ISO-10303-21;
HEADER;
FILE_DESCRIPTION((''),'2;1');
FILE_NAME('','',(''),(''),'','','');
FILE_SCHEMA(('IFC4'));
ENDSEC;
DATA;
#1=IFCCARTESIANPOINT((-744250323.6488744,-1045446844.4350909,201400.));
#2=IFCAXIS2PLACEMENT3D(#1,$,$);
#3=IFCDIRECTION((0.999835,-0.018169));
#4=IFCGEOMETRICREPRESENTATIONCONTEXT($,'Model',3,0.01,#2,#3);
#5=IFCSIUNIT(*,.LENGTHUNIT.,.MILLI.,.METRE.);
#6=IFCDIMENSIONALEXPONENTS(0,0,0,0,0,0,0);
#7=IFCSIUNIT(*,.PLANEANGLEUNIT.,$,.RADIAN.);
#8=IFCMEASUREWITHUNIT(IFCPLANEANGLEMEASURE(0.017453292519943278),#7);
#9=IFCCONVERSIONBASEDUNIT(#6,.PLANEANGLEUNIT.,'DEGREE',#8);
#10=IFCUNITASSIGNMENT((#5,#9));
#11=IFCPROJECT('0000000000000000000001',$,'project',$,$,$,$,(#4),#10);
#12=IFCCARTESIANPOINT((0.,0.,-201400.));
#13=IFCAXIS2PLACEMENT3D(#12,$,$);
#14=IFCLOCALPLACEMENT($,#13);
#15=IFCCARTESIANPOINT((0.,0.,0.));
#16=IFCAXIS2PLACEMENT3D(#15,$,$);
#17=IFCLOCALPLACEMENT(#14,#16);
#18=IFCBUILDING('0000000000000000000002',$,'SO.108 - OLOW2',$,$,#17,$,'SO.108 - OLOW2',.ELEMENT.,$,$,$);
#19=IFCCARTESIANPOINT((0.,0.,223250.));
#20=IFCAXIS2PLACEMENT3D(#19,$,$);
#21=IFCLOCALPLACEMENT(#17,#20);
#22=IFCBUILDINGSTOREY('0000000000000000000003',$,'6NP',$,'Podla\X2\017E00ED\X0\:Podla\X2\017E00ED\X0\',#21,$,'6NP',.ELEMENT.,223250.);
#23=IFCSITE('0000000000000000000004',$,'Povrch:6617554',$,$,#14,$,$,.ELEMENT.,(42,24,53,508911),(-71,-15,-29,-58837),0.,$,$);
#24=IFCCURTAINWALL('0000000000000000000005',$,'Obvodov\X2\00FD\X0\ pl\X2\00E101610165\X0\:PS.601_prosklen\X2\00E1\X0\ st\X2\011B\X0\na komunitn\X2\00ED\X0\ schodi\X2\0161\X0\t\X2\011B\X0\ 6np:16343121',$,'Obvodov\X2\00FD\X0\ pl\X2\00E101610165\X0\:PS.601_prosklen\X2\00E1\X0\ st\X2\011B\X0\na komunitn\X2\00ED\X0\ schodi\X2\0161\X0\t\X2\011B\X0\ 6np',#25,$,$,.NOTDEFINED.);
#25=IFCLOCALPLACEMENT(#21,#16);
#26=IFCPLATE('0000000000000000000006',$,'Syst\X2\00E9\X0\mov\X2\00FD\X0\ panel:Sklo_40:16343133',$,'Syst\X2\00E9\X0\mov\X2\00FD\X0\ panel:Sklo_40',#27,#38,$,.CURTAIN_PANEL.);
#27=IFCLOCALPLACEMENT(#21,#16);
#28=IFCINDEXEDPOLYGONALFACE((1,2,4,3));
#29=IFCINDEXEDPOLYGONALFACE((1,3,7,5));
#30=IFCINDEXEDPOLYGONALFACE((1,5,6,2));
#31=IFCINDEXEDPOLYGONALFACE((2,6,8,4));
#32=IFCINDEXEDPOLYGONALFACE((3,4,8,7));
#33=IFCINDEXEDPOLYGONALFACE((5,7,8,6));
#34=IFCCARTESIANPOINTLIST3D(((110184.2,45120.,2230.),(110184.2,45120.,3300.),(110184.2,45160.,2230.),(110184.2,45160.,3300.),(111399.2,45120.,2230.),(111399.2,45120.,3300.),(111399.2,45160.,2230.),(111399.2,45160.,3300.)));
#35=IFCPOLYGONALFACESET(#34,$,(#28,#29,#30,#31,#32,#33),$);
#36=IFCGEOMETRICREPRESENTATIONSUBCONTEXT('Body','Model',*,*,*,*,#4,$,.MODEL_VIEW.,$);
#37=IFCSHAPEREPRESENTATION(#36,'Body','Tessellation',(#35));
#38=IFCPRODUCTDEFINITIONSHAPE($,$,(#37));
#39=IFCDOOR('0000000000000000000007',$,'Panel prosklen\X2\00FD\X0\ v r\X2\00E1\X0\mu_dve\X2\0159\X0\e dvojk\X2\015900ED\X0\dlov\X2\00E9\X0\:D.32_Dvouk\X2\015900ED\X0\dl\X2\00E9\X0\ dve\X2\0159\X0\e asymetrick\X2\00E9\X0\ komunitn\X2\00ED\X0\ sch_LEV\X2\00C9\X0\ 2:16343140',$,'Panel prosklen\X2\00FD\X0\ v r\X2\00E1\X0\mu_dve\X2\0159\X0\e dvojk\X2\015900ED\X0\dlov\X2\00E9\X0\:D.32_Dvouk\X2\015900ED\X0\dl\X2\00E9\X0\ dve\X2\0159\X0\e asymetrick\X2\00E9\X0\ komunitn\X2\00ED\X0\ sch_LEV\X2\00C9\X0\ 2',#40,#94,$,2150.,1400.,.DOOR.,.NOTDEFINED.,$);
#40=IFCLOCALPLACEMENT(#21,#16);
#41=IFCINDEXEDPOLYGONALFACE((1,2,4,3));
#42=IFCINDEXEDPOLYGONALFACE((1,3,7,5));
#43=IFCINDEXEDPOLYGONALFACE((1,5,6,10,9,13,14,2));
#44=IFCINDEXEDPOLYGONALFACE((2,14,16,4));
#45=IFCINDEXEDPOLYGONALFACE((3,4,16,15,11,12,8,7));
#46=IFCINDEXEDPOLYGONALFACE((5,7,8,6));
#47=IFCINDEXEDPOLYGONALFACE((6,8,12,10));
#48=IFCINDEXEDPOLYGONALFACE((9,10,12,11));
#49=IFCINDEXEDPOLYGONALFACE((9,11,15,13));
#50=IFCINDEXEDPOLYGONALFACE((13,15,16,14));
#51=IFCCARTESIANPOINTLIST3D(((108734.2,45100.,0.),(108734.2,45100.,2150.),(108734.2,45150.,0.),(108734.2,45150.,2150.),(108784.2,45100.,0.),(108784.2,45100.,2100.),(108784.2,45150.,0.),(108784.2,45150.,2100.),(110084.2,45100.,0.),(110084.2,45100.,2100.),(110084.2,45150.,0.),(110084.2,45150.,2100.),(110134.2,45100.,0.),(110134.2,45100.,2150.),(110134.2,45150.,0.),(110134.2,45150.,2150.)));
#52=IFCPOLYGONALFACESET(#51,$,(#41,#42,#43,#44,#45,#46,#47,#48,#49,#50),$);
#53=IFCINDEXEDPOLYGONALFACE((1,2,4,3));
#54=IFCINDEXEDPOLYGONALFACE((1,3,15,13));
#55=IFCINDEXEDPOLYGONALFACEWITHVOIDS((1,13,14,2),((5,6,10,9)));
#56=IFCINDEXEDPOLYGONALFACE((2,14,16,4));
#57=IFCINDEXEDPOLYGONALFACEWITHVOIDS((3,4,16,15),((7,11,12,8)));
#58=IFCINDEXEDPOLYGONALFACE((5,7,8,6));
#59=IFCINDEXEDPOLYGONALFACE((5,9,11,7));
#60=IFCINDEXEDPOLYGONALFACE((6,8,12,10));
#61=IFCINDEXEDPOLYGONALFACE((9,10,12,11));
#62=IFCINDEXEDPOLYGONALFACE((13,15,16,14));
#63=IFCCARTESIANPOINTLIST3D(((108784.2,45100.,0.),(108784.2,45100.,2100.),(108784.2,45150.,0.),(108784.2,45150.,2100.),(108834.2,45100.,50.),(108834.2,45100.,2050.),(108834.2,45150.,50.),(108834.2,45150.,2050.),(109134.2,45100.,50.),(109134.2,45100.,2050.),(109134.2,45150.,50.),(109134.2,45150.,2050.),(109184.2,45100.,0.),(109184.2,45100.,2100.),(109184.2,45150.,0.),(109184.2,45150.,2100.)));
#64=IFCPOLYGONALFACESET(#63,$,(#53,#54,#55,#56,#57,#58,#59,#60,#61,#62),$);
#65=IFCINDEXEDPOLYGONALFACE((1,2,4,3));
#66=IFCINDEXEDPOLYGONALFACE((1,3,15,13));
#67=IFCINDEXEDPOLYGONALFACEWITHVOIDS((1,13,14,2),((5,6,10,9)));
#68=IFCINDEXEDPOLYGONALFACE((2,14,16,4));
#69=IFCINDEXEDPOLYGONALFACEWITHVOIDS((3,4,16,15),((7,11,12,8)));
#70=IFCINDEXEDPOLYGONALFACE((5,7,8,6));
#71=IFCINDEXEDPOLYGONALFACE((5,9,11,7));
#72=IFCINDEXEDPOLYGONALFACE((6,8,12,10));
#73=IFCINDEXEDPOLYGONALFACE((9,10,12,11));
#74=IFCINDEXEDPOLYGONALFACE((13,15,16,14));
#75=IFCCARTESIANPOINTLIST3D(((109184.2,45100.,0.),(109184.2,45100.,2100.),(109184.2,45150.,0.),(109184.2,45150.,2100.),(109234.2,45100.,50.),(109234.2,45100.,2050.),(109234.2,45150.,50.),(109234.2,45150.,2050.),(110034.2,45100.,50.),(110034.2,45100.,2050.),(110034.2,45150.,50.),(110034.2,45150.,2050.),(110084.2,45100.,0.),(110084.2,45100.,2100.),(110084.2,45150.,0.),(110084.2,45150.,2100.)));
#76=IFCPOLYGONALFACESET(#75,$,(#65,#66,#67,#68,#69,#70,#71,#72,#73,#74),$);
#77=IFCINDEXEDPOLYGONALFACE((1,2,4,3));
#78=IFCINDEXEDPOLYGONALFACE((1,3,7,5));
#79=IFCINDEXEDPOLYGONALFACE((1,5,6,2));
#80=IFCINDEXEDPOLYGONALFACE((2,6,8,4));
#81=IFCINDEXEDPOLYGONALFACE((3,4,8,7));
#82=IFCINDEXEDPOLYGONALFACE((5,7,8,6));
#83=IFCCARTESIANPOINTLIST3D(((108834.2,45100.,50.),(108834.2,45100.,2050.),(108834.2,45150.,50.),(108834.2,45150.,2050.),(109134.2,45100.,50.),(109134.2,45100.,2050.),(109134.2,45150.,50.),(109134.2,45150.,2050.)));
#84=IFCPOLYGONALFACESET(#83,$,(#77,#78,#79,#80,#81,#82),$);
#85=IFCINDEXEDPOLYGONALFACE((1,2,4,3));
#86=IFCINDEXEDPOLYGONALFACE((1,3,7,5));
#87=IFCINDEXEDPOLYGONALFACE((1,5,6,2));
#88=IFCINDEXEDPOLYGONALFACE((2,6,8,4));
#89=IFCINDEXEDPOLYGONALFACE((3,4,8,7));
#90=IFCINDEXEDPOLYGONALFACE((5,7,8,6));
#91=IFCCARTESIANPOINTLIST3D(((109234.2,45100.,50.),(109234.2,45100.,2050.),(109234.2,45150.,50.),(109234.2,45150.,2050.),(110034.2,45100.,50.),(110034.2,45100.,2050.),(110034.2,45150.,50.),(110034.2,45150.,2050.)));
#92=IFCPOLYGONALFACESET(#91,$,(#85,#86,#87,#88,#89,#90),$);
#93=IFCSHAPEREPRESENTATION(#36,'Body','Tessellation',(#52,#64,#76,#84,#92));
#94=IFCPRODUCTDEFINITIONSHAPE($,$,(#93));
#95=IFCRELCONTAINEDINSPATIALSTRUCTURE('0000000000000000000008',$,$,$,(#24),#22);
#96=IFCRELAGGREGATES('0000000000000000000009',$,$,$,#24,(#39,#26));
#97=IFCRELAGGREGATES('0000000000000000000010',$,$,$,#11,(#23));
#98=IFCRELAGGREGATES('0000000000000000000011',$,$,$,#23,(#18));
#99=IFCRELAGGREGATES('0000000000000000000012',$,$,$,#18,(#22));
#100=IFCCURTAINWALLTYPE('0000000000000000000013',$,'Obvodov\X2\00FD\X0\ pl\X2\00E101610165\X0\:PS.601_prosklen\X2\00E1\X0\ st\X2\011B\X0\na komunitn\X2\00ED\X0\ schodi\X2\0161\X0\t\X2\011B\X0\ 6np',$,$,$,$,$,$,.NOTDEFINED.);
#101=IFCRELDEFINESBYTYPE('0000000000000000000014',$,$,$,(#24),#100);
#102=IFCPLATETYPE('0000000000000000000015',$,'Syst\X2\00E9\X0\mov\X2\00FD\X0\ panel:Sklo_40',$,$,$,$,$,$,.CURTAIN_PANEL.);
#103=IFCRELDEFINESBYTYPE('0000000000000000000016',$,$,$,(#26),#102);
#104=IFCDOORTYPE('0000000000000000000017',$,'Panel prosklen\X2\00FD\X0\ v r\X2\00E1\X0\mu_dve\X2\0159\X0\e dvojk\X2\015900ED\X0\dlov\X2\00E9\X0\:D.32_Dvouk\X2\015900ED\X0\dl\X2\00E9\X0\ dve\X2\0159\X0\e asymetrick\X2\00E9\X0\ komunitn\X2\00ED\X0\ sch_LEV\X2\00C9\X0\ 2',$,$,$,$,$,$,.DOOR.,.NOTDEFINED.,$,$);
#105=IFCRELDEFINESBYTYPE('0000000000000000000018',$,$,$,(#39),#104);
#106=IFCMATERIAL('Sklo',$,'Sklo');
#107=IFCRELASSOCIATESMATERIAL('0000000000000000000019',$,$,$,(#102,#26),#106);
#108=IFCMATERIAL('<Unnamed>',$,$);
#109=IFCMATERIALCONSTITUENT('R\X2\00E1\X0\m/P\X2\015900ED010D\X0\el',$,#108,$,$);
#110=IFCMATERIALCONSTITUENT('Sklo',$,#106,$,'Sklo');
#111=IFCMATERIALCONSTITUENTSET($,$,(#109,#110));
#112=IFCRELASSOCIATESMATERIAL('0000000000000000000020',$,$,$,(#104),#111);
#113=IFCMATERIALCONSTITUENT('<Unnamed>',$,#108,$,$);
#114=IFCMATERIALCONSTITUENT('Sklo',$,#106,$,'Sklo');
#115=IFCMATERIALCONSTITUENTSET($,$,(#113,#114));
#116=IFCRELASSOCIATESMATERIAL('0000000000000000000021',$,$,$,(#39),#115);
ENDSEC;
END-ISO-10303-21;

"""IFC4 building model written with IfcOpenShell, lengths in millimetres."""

from ifc_helpers import new_model, entity, si_unit, converted_unit, direction, frame, origin, place, context, subcontext, project, spatial, indexed_curve, outline, extrude, source, transform, mapped, material, constituent, constituent_set, type_object, type_shapes, element, aggregate, save


model = new_model("IFC4")

# Units and contexts
model_context = context("Model", 3, precision=0.01, world=frame((-744250323.6488744, -1045446844.4350909, 201400.0)), true_north=direction((0.999835, -0.018169)))
body_context = subcontext(model_context, "Body", "Model", "MODEL_VIEW")
ifc_project = project(units=[si_unit("LENGTHUNIT", "METRE", prefix="MILLI"), converted_unit("PLANEANGLEUNIT", "DEGREE", entity("IfcPlaneAngleMeasure", 0.017453292519943278), si_unit("PLANEANGLEUNIT", "RADIAN"), dimensions=[0, 0, 0, 0, 0, 0, 0])], contexts=[model_context])

# Site, building, storey
site_placement = place(None, frame((0.0, 0.0, -201400.0)))
site = spatial("IfcSite", under=ifc_project, at=site_placement, Name="Povrch:6617554", CompositionType="ELEMENT", RefLatitude=(42, 24, 53, 508911), RefLongitude=(-71, -15, -29, -58837), RefElevation=0.0)
building_placement = place(site_placement, origin())
building = spatial("IfcBuilding", under=site, at=building_placement, Name="SO.108 - OLOW2", LongName="SO.108 - OLOW2", CompositionType="ELEMENT")
storey_placement = place(building_placement, frame((0.0, 0.0, 223250.0)))
storey = spatial("IfcBuildingStorey", under=building, at=storey_placement, Name="6NP", ObjectType="Podlaží:Podlaží", LongName="6NP", CompositionType="ELEMENT", Elevation=223250.0)

# Shared definitions
ifc_material_1 = material(Name="<Unnamed>")

# Curtain wall, plate, door
curtain_wall_type_1 = type_object("IfcCurtainWallType", Name="Obvodový plášť:PS.601_prosklená stěna komunitní schodiště 6np", PredefinedType="NOTDEFINED")
curtain_wall_1_placement = place(storey_placement, frame((0.0, 0.0, -223250.0)))
curtain_wall_1 = element("IfcCurtainWall", 1, at=curtain_wall_1_placement, inside=storey, type_object=curtain_wall_type_1, Name="Obvodový plášť:PS.601_prosklená stěna komunitní schodiště 6np:16343121", ObjectType="Obvodový plášť:PS.601_prosklená stěna komunitní schodiště 6np", PredefinedType="NOTDEFINED")
ifc_material_2 = material(Name="Sklo", Category="Sklo")
plate_type_1 = type_object("IfcPlateType", Name="Systémový panel:Sklo_40", PredefinedType="CURTAIN_PANEL", material=ifc_material_2)
shared_shape_1 = source(origin(), body_context, "Body", "SweptSolid", [
    extrude(outline(indexed_curve([(-20.0, -607.5), (20.0, -607.5), (20.0, 607.5), (-20.0, 607.5), (-20.0, -607.5)], self_intersect=False)), frame((0.0, 0.0, 0.0), z_axis=(0.0, 0.0, 1.0), x_axis=(0.0, 1.0, 0.0)), (0.0, 0.0, 1.0), 1070.0),
])
type_shapes(plate_type_1, [shared_shape_1])
plate_1_placement = place(curtain_wall_1_placement, frame((110791.7, 45140.0, 225480.0), z_axis=(0.0, 0.0, 1.0), x_axis=(-1.0, 0.0, 0.0)))
plate_1 = element("IfcPlate", 2, at=plate_1_placement, type_object=plate_type_1, material=ifc_material_2, Name="Systémový panel:Sklo_40:16343133", ObjectType="Systémový panel:Sklo_40", PredefinedType="CURTAIN_PANEL", context=body_context, shape_type="MappedRepresentation", body=[
    mapped(shared_shape_1, transform((0.0, 0.0, 0.0), scale=1.0)),
])
ifc_constituent_1 = constituent(ifc_material_1, Name="<Unnamed>")
ifc_constituent_2 = constituent(ifc_material_2, Name="Sklo", Category="Sklo")
ifc_constituent_set_1 = constituent_set(constituents=[ifc_constituent_1, ifc_constituent_2])
ifc_constituent_3 = constituent(ifc_material_1, Name="Rám/Příčel")
ifc_constituent_4 = constituent(ifc_material_2, Name="Sklo", Category="Sklo")
ifc_constituent_set_2 = constituent_set(constituents=[ifc_constituent_3, ifc_constituent_4])
door_type = type_object("IfcDoorType", Name="Panel prosklený v rámu_dveře dvojkřídlové:D.32_Dvoukřídlé dveře asymetrické komunitní sch_LEVÉ 2", OperationType="NOTDEFINED", PredefinedType="DOOR", material=ifc_constituent_set_2)
shared_shape_2 = source(origin(), body_context, "Body", "SweptSolid", [
    extrude(outline(indexed_curve([(-700.0, -1087.5), (700.0, -1087.5), (700.0, 1062.5), (650.0, 1062.5), (650.0, -1037.5), (-650.0, -1037.5), (-650.0, 1062.5), (-700.0, 1062.5), (-700.0, -1087.5)], self_intersect=False)), frame((0.0, -10.0, 1062.5), z_axis=(0.0, 1.0, 0.0), x_axis=(1.0, 0.0, 0.0)), (0.0, 0.0, 1.0), 50.0),
    extrude(outline(indexed_curve([(-1050.0, -200.0), (1050.0, -200.0), (1050.0, 200.0), (-1050.0, 200.0), (-1050.0, -200.0)], self_intersect=False), holes=[indexed_curve([(-1000.0, -150.0), (-1000.0, 150.0), (1000.0, 150.0), (1000.0, -150.0), (-1000.0, -150.0)], self_intersect=False)]), frame((450.0, -10.0, 1050.0), z_axis=(0.0, 1.0, 0.0), x_axis=(0.0, 0.0, -1.0)), (0.0, 0.0, 1.0), 50.0),
    extrude(outline(indexed_curve([(-1050.0, -450.0), (1050.0, -450.0), (1050.0, 450.0), (-1050.0, 450.0), (-1050.0, -450.0)], self_intersect=False), holes=[indexed_curve([(-1000.0, -400.0), (-1000.0, 400.0), (1000.0, 400.0), (1000.0, -400.0), (-1000.0, -400.0)], self_intersect=False)]), frame((-200.0, -10.0, 1050.0), z_axis=(0.0, 1.0, 0.0), x_axis=(0.0, 0.0, -1.0)), (0.0, 0.0, 1.0), 50.0),
    extrude(outline(indexed_curve([(-25.0, -150.0), (25.0, -150.0), (25.0, 150.0), (-25.0, 150.0), (-25.0, -150.0)], self_intersect=False)), frame((450.0, 15.0, 50.0), z_axis=(0.0, 0.0, 1.0), x_axis=(0.0, 1.0, 0.0)), (0.0, 0.0, 1.0), 2000.0),
    extrude(outline(indexed_curve([(-25.0, -400.0), (25.0, -400.0), (25.0, 400.0), (-25.0, 400.0), (-25.0, -400.0)], self_intersect=False)), frame((-200.0, 15.0, 50.0), z_axis=(0.0, 0.0, 1.0), x_axis=(0.0, 1.0, 0.0)), (0.0, 0.0, 1.0), 2000.0),
])
type_shapes(door_type, [shared_shape_2])
door_placement = place(curtain_wall_1_placement, frame((109434.2, 45140.0, 223250.0), z_axis=(0.0, 0.0, 1.0), x_axis=(-1.0, 0.0, 0.0)))
door = element("IfcDoor", 3, at=door_placement, type_object=door_type, material=ifc_constituent_set_1, Name="Panel prosklený v rámu_dveře dvojkřídlové:D.32_Dvoukřídlé dveře asymetrické komunitní sch_LEVÉ 2:16343140", ObjectType="Panel prosklený v rámu_dveře dvojkřídlové:D.32_Dvoukřídlé dveře asymetrické komunitní sch_LEVÉ 2", OperationType="NOTDEFINED", OverallHeight=2150.0, OverallWidth=1400.0, PredefinedType="DOOR", context=body_context, shape_type="MappedRepresentation", body=[
    mapped(shared_shape_2, transform((0.0, 0.0, 0.0), scale=1.0)),
])
aggregate(curtain_wall_1, [door, plate_1])

save(model, "model.ifc")
